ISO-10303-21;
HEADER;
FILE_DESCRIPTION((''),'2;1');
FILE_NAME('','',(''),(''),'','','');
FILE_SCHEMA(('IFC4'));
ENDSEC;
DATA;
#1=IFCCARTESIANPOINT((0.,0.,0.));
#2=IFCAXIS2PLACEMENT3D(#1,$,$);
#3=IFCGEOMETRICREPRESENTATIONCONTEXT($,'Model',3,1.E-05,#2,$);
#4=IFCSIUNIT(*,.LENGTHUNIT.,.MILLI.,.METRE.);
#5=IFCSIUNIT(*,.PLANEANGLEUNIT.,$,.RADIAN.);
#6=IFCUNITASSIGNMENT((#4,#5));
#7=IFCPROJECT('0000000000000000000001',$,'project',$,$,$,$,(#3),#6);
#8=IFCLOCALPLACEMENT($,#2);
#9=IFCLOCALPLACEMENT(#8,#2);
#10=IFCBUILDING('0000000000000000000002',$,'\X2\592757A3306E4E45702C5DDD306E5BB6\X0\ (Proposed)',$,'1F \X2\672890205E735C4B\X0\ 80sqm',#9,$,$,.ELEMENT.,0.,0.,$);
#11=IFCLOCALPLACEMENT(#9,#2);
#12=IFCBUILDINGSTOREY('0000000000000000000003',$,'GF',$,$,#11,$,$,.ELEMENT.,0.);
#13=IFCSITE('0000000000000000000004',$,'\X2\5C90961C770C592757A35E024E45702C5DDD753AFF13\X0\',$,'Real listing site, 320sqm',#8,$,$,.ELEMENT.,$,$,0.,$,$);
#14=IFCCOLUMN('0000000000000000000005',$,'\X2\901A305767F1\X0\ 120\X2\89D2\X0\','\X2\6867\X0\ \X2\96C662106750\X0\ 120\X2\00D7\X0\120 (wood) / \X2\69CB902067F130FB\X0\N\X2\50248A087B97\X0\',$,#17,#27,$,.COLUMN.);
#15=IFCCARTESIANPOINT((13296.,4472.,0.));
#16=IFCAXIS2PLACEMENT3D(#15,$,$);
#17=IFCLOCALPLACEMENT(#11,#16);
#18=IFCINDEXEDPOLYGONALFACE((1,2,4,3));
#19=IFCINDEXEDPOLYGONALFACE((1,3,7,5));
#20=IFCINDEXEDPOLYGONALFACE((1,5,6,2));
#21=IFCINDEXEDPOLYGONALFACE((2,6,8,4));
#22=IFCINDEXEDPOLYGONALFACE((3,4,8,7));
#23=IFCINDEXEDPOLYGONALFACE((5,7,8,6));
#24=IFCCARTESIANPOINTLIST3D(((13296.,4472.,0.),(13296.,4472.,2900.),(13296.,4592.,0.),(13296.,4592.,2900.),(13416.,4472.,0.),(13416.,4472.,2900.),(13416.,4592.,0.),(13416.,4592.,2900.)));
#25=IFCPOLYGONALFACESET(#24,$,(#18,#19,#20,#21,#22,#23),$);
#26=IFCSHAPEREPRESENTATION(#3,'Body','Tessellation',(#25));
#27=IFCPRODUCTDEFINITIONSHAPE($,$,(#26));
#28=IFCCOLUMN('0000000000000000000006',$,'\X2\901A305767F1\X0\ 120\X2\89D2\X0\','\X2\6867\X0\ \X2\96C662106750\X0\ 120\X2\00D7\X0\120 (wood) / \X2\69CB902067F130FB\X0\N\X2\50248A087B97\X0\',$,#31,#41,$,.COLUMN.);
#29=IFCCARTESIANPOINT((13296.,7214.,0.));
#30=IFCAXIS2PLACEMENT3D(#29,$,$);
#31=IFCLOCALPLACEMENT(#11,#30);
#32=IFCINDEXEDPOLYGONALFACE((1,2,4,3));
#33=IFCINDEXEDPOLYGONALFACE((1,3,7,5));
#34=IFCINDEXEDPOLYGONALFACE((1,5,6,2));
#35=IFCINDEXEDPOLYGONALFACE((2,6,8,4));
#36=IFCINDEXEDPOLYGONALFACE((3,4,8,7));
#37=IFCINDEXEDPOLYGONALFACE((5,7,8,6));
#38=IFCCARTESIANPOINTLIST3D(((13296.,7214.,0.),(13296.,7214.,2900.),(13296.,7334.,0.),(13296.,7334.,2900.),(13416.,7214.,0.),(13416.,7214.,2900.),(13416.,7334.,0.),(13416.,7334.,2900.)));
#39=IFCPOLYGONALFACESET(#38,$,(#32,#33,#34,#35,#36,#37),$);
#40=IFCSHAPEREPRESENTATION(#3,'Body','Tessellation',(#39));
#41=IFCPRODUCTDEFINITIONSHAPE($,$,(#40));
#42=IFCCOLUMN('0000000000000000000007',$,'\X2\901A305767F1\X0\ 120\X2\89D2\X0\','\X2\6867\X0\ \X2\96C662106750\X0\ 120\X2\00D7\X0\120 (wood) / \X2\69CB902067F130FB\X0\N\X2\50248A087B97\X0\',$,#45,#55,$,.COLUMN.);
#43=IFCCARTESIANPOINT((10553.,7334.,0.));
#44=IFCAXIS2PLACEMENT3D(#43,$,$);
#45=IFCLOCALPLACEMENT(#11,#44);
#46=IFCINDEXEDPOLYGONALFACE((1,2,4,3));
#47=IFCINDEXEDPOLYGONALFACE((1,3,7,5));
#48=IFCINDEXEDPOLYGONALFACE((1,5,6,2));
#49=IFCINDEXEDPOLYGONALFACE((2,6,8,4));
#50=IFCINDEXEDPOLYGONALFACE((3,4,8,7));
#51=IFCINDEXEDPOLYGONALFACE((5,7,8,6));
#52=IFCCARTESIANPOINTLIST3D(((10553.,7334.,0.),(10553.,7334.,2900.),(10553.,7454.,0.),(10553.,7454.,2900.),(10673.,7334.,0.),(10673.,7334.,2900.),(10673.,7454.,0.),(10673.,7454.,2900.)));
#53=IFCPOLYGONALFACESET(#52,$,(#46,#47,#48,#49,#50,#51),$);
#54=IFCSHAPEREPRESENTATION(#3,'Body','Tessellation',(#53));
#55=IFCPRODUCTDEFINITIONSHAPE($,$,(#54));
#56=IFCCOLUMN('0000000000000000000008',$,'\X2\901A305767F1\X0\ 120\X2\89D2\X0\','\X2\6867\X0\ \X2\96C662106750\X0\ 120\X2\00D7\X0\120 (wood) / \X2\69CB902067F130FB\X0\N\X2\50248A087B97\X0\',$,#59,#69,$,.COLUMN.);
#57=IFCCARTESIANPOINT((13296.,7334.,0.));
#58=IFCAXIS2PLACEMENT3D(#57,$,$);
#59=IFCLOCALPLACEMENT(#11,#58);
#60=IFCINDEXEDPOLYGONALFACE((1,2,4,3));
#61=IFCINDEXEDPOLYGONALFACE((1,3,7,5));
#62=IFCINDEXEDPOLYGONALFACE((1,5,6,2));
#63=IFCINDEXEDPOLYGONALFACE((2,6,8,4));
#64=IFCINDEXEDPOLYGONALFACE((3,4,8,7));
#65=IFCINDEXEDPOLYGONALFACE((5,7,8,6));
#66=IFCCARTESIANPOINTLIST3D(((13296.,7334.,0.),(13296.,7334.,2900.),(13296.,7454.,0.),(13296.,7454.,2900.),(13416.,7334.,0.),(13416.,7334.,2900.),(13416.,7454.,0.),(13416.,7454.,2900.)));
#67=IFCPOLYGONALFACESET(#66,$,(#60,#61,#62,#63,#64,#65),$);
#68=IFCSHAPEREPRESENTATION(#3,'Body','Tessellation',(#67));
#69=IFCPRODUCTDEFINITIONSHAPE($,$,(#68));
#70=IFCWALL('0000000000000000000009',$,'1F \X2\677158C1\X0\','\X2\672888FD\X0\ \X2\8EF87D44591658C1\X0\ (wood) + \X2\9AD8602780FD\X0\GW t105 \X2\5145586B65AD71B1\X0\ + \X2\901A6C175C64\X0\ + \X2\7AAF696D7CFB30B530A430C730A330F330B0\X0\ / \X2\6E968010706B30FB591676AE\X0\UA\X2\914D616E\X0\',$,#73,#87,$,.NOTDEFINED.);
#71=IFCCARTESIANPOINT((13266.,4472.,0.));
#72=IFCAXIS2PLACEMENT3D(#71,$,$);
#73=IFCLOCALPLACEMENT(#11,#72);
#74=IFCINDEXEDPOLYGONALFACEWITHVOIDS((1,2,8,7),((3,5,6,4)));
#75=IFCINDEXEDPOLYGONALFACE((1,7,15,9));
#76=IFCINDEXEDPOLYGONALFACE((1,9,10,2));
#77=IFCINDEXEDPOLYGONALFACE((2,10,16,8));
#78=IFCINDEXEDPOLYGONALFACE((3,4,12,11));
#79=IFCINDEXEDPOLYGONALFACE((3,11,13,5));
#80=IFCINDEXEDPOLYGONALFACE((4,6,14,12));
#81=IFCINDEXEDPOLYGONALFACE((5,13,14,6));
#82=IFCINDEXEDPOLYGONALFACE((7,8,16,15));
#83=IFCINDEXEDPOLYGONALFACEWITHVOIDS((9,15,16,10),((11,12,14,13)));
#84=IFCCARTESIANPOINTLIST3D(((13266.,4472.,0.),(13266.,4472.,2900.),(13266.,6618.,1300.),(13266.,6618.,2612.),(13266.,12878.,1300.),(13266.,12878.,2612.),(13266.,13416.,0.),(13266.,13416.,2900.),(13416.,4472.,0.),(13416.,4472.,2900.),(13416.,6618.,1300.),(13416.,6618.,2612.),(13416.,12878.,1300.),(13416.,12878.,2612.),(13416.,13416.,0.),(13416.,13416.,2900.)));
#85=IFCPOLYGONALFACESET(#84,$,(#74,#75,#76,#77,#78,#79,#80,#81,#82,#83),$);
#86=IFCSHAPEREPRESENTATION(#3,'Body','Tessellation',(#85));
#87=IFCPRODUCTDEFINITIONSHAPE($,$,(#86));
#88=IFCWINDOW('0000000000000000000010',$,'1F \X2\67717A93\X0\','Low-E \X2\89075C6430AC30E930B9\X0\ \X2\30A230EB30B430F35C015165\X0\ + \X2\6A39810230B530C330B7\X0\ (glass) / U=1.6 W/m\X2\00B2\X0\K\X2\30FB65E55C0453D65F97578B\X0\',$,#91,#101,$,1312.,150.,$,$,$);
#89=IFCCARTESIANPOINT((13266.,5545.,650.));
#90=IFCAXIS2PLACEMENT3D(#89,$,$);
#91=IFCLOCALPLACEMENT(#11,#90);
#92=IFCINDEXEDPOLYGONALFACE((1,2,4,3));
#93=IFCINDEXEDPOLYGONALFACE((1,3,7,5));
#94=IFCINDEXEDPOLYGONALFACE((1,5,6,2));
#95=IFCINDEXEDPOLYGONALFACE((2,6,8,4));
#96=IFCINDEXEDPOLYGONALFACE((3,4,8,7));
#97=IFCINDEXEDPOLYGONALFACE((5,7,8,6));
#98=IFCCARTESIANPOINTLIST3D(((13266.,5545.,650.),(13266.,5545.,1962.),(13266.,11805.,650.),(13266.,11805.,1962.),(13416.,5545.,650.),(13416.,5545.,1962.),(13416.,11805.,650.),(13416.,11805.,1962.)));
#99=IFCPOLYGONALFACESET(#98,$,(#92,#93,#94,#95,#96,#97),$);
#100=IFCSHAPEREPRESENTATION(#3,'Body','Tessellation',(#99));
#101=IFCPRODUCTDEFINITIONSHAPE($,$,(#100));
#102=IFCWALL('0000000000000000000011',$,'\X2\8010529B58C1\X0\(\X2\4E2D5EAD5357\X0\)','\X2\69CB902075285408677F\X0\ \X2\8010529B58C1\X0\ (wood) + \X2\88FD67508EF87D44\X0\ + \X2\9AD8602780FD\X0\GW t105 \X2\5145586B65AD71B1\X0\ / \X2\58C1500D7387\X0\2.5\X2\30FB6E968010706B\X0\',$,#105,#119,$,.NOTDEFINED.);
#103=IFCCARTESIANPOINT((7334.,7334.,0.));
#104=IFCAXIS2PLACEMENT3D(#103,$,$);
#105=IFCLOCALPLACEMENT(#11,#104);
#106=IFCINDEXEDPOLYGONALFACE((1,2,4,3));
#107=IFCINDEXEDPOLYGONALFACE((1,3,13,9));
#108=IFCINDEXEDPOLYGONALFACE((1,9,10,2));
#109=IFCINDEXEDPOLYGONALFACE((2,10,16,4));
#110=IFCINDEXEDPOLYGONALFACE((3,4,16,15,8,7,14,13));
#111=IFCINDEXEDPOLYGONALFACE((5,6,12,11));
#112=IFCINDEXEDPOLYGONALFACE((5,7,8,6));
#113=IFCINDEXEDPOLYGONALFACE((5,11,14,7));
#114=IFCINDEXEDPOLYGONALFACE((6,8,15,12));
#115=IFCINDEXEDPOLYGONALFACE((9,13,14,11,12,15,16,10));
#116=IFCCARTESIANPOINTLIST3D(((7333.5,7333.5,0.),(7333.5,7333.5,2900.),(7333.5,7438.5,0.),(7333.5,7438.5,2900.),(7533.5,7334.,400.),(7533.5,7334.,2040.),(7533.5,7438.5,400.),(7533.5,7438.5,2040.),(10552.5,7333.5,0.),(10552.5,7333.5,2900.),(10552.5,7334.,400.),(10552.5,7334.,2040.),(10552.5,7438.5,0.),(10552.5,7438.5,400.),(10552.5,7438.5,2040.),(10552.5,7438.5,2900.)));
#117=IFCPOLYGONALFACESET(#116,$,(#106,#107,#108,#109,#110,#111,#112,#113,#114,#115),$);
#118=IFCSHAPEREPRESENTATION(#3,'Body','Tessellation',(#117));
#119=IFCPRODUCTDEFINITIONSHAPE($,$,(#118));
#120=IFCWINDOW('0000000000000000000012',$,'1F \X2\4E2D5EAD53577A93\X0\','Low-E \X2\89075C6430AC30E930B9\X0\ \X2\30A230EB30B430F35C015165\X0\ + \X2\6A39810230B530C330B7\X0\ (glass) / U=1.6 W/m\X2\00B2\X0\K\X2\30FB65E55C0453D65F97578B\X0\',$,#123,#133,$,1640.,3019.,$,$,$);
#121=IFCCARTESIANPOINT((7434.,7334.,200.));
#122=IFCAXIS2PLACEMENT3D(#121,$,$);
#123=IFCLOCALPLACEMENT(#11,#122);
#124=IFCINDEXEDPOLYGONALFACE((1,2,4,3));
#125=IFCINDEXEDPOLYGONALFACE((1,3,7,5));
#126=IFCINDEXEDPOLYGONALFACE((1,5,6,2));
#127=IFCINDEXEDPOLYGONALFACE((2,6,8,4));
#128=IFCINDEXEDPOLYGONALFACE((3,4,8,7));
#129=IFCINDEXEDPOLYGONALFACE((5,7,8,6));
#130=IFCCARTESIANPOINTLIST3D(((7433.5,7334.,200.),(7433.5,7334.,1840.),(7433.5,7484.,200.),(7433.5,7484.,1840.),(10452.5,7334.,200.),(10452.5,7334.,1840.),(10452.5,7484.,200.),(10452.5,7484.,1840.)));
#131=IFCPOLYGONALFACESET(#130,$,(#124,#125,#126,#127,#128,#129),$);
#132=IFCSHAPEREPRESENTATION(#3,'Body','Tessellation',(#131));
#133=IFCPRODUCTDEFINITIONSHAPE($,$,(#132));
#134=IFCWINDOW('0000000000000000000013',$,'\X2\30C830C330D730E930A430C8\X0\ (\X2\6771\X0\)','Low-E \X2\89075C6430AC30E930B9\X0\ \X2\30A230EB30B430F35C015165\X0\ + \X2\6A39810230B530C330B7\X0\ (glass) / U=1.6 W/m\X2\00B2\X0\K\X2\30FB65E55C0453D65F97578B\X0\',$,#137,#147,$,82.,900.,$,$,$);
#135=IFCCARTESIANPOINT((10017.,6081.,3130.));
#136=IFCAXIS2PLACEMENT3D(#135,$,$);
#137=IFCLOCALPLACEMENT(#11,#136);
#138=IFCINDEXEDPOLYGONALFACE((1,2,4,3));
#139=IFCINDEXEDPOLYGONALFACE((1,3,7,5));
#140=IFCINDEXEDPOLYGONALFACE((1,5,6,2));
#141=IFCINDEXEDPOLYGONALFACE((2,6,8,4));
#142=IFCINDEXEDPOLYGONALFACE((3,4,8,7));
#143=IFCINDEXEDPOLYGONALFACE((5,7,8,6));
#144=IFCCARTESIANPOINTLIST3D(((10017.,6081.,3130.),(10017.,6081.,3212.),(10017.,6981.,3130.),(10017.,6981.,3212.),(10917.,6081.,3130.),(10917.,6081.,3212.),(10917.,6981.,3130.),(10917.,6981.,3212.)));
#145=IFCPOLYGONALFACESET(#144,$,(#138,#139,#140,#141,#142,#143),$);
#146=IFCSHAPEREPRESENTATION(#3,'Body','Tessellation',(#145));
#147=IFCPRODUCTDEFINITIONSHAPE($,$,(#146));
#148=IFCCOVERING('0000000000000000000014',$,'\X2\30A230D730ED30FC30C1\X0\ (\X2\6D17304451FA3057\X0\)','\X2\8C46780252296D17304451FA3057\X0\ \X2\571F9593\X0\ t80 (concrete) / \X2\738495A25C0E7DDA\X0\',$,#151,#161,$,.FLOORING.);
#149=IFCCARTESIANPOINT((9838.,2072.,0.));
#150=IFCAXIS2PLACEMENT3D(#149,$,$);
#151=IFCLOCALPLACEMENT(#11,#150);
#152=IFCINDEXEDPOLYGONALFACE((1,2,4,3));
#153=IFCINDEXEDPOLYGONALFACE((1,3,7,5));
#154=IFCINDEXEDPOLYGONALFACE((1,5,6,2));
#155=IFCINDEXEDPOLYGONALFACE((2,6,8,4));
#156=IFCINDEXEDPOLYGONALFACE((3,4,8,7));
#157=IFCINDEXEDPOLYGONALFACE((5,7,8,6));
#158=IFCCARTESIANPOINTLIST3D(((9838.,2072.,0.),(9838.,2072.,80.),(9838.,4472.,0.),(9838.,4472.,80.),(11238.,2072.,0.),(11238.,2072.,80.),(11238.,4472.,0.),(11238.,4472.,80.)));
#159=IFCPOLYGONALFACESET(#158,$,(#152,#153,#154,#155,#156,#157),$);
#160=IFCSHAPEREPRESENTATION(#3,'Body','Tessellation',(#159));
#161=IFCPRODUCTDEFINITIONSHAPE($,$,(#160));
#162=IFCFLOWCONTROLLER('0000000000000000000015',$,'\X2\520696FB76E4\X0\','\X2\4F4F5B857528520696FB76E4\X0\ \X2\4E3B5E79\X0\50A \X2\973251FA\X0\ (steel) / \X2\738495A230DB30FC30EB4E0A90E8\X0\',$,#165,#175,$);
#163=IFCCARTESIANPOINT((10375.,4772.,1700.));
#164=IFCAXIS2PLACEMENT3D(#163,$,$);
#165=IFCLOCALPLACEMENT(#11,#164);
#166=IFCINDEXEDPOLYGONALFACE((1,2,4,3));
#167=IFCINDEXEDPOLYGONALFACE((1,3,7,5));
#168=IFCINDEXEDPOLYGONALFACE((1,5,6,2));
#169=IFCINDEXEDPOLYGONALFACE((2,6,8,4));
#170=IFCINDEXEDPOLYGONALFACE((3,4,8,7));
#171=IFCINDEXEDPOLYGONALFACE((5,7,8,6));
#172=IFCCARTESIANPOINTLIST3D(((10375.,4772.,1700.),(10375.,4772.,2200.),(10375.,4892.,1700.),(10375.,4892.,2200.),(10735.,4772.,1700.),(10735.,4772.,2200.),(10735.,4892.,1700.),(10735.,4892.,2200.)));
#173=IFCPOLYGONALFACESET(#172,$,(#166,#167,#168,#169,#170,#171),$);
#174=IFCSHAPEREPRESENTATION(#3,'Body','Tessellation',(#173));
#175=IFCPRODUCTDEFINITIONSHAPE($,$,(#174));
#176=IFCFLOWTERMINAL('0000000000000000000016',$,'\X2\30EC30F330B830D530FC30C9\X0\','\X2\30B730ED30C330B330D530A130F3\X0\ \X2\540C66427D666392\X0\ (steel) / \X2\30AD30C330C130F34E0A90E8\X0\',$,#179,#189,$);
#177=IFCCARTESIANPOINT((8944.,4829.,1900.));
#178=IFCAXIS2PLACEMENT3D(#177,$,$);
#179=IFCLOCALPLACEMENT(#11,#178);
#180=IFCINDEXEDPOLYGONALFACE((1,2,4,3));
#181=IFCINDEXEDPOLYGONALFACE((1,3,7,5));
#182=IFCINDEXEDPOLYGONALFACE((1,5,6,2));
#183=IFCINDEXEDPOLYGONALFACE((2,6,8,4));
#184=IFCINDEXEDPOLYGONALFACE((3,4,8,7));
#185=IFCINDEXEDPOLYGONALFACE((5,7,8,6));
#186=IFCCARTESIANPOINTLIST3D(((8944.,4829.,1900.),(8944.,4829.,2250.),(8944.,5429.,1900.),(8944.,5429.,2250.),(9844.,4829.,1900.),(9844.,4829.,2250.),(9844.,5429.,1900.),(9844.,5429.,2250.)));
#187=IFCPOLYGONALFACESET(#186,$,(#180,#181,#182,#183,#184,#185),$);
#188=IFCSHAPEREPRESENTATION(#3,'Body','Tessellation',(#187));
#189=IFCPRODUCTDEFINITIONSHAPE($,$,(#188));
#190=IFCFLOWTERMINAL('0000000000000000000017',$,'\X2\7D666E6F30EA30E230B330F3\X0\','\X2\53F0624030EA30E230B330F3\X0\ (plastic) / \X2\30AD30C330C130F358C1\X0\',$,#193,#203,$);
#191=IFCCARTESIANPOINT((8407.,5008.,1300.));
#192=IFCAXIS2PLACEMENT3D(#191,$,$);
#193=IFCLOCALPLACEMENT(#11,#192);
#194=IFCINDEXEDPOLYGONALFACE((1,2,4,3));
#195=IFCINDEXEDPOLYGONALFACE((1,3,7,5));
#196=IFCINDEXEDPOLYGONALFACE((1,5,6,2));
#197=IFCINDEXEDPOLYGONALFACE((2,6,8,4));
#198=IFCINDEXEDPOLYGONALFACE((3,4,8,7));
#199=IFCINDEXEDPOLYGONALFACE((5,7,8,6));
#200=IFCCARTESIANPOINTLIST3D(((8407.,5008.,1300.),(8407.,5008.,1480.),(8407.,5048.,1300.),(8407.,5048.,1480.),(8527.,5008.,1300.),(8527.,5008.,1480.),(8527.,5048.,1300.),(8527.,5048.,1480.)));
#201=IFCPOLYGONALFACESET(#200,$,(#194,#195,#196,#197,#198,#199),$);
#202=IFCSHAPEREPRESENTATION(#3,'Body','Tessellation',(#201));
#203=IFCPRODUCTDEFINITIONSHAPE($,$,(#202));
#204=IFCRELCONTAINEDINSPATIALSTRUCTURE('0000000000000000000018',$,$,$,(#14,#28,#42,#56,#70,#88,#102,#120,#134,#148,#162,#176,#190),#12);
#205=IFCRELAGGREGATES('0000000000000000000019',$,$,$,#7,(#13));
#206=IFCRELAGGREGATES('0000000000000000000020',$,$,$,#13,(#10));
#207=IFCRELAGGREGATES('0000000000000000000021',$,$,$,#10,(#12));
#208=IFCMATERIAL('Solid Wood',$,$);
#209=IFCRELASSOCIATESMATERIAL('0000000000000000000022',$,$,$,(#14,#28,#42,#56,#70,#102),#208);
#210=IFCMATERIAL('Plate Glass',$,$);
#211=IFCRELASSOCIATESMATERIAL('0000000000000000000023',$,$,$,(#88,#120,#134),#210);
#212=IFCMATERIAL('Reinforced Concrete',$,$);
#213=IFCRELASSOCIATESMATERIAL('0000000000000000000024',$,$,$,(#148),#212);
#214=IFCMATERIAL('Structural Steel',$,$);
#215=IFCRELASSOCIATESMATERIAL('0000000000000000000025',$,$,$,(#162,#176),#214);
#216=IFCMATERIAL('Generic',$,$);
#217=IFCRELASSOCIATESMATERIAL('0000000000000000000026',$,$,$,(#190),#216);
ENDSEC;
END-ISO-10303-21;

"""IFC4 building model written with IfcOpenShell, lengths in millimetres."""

from ifc_helpers import new_model, si_unit, frame, frame_2d, origin, place, context, project, spatial, rectangle, extrude, material, element, fill, save


model = new_model("IFC4")

# Units and contexts
model_context = context("Model", 3, precision=1e-05, world=origin())
ifc_project = project(units=[si_unit("LENGTHUNIT", "METRE", prefix="MILLI"), si_unit("PLANEANGLEUNIT", "RADIAN")], contexts=[model_context])

# Site, building, storey
site_placement = place(None, origin())
site = spatial("IfcSite", under=ifc_project, at=site_placement, Name="岐阜県大垣市久瀬川町３", ObjectType="Real listing site, 320sqm", CompositionType="ELEMENT", RefElevation=0.0)
building_placement = place(site_placement, origin())
building = spatial("IfcBuilding", under=site, at=building_placement, Name="大垣の久瀬川の家 (Proposed)", ObjectType="1F 木造平屋 80sqm", CompositionType="ELEMENT", ElevationOfRefHeight=0.0, ElevationOfTerrain=0.0)
storey_placement = place(building_placement, origin())
storey = spatial("IfcBuildingStorey", under=building, at=storey_placement, Name="GF", CompositionType="ELEMENT", Elevation=0.0)

# Columns
ifc_material_1 = material(Name="Solid Wood")
column_1_placement = place(storey_placement, frame((13296.0, 4472.0, 0.0)))
element("IfcColumn", 1, at=column_1_placement, inside=storey, material=ifc_material_1, Name="通し柱 120角", Description="桧 集成材 120×120 (wood) / 構造柱・N値計算", PredefinedType="COLUMN", context=model_context, shape_type="SweptSolid", body=[
    extrude(rectangle(XDim=120.0, YDim=120.0, at=frame_2d((60.0, 60.0))), frame((13296.0, 4472.0, 0.0)), (0.0, 0.0, 1.0), 2900.0),
])
column_2_placement = place(storey_placement, frame((13296.0, 7214.0, 0.0)))
element("IfcColumn", 2, at=column_2_placement, inside=storey, material=ifc_material_1, Name="通し柱 120角", Description="桧 集成材 120×120 (wood) / 構造柱・N値計算", PredefinedType="COLUMN", context=model_context, shape_type="SweptSolid", body=[
    extrude(rectangle(XDim=120.0, YDim=120.0, at=frame_2d((60.0, 60.0))), frame((13296.0, 7214.0, 0.0)), (0.0, 0.0, 1.0), 2900.0),
])
column_3_placement = place(storey_placement, frame((10553.0, 7334.0, 0.0)))
element("IfcColumn", 3, at=column_3_placement, inside=storey, material=ifc_material_1, Name="通し柱 120角", Description="桧 集成材 120×120 (wood) / 構造柱・N値計算", PredefinedType="COLUMN", context=model_context, shape_type="SweptSolid", body=[
    extrude(rectangle(XDim=120.0, YDim=120.0, at=frame_2d((60.0, 60.0))), frame((10553.0, 7334.0, 0.0)), (0.0, 0.0, 1.0), 2900.0),
])
column_4_placement = place(storey_placement, frame((13296.0, 7334.0, 0.0)))
element("IfcColumn", 4, at=column_4_placement, inside=storey, material=ifc_material_1, Name="通し柱 120角", Description="桧 集成材 120×120 (wood) / 構造柱・N値計算", PredefinedType="COLUMN", context=model_context, shape_type="SweptSolid", body=[
    extrude(rectangle(XDim=120.0, YDim=120.0, at=frame_2d((60.0, 60.0))), frame((13296.0, 7334.0, 0.0)), (0.0, 0.0, 1.0), 2900.0),
])

# Walls, openings, windows
wall_1_placement = place(storey_placement, frame((13266.0, 4472.0, 0.0)))
wall_1 = element("IfcWall", 5, at=wall_1_placement, inside=storey, material=ifc_material_1, Name="1F 東壁", Description="木製 軸組外壁 (wood) + 高性能GW t105 充填断熱 + 通気層 + 窯業系サイディング / 準耐火・外皮UA配慮", PredefinedType="NOTDEFINED", context=model_context, shape_type="SweptSolid", body=[
    extrude(rectangle(XDim=150.0, YDim=8944.0, at=frame_2d((75.0, 4472.0))), frame((13266.0, 4472.0, 0.0)), (0.0, 0.0, 1.0), 2900.0),
])
opening_1_placement = place(storey_placement, frame((13266.0, 5545.0, 650.0)))
opening_1 = element("IfcOpeningElement", 6, at=opening_1_placement, cuts=wall_1, PredefinedType="NOTDEFINED", context=model_context, shape_type="SweptSolid", body=[
    extrude(rectangle(XDim=150.0, YDim=6260.0, at=frame_2d((75.0, 3130.0))), frame((13266.0, 5545.0, 650.0)), (0.0, 0.0, 1.0), 1312.0),
])
ifc_material_2 = material(Name="Plate Glass")
window_1_placement = place(storey_placement, frame((13266.0, 5545.0, 650.0)))
window_1 = element("IfcWindow", 7, at=window_1_placement, inside=storey, material=ifc_material_2, Name="1F 東窓", Description="Low-E 複層ガラス アルゴン封入 + 樹脂サッシ (glass) / U=1.6 W/m²K・日射取得型", OverallHeight=1312.0, OverallWidth=150.0, context=model_context, shape_type="SweptSolid", body=[
    extrude(rectangle(XDim=150.0, YDim=6260.0, at=frame_2d((75.0, 3130.0))), frame((13266.0, 5545.0, 650.0)), (0.0, 0.0, 1.0), 1312.0),
])
fill(opening_1, window_1)
wall_2_placement = place(storey_placement, frame((7334.0, 7334.0, 0.0)))
wall_2 = element("IfcWall", 8, at=wall_2_placement, inside=storey, material=ifc_material_1, Name="耐力壁(中庭南)", Description="構造用合板 耐力壁 (wood) + 製材軸組 + 高性能GW t105 充填断熱 / 壁倍率2.5・準耐火", PredefinedType="NOTDEFINED", context=model_context, shape_type="SweptSolid", body=[
    extrude(rectangle(XDim=3219.0, YDim=105.0, at=frame_2d((1609.0, 52.0))), frame((7334.0, 7334.0, 0.0)), (0.0, 0.0, 1.0), 2900.0),
])
opening_2_placement = place(storey_placement, frame((7434.0, 7334.0, 200.0)))
opening_2 = element("IfcOpeningElement", 9, at=opening_2_placement, cuts=wall_2, PredefinedType="NOTDEFINED", context=model_context, shape_type="SweptSolid", body=[
    extrude(rectangle(XDim=3019.0, YDim=150.0, at=frame_2d((1509.0, 75.0))), frame((7434.0, 7334.0, 200.0)), (0.0, 0.0, 1.0), 1640.0),
])
window_2_placement = place(storey_placement, frame((7434.0, 7334.0, 200.0)))
window_2 = element("IfcWindow", 10, at=window_2_placement, inside=storey, material=ifc_material_2, Name="1F 中庭南窓", Description="Low-E 複層ガラス アルゴン封入 + 樹脂サッシ (glass) / U=1.6 W/m²K・日射取得型", OverallHeight=1640.0, OverallWidth=3019.0, context=model_context, shape_type="SweptSolid", body=[
    extrude(rectangle(XDim=3019.0, YDim=150.0, at=frame_2d((1509.0, 75.0))), frame((7434.0, 7334.0, 200.0)), (0.0, 0.0, 1.0), 1640.0),
])
fill(opening_2, window_2)

# Window
window_3_placement = place(storey_placement, frame((10017.0, 6081.0, 3130.0)))
element("IfcWindow", 11, at=window_3_placement, inside=storey, material=ifc_material_2, Name="トップライト (東)", Description="Low-E 複層ガラス アルゴン封入 + 樹脂サッシ (glass) / U=1.6 W/m²K・日射取得型", OverallHeight=82.0, OverallWidth=900.0, context=model_context, shape_type="SweptSolid", body=[
    extrude(rectangle(XDim=900.0, YDim=900.0, at=frame_2d((450.0, 450.0))), frame((10017.0, 6081.0, 3130.0)), (0.0, 0.0, 1.0), 82.0),
])

# Shared definitions
ifc_material_3 = material(Name="Structural Steel")

# Covering
ifc_material_4 = material(Name="Reinforced Concrete")
covering_placement = place(storey_placement, frame((9838.0, 2072.0, 0.0)))
element("IfcCovering", 12, at=covering_placement, inside=storey, material=ifc_material_4, Name="アプローチ (洗い出し)", Description="豆砂利洗い出し 土間 t80 (concrete) / 玄関導線", PredefinedType="FLOORING", context=model_context, shape_type="SweptSolid", body=[
    extrude(rectangle(XDim=1400.0, YDim=2400.0, at=frame_2d((700.0, 1200.0))), frame((9838.0, 2072.0, 0.0)), (0.0, 0.0, 1.0), 80.0),
])

# Flow controller
flow_controller_placement = place(storey_placement, frame((10375.0, 4772.0, 1700.0)))
element("IfcFlowController", 13, at=flow_controller_placement, inside=storey, material=ifc_material_3, Name="分電盤", Description="住宅用分電盤 主幹50A 露出 (steel) / 玄関ホール上部", context=model_context, shape_type="SweptSolid", body=[
    extrude(rectangle(XDim=360.0, YDim=120.0, at=frame_2d((180.0, 60.0))), frame((10375.0, 4772.0, 1700.0)), (0.0, 0.0, 1.0), 500.0),
])

# Flow terminals
flow_terminal_1_placement = place(storey_placement, frame((8944.0, 4829.0, 1900.0)))
element("IfcFlowTerminal", 14, at=flow_terminal_1_placement, inside=storey, material=ifc_material_3, Name="レンジフード", Description="シロッコファン 同時給排 (steel) / キッチン上部", context=model_context, shape_type="SweptSolid", body=[
    extrude(rectangle(XDim=900.0, YDim=600.0, at=frame_2d((450.0, 300.0))), frame((8944.0, 4829.0, 1900.0)), (0.0, 0.0, 1.0), 350.0),
])
ifc_material_5 = material(Name="Generic")
flow_terminal_2_placement = place(storey_placement, frame((8407.0, 5008.0, 1300.0)))
element("IfcFlowTerminal", 15, at=flow_terminal_2_placement, inside=storey, material=ifc_material_5, Name="給湯リモコン", Description="台所リモコン (plastic) / キッチン壁", context=model_context, shape_type="SweptSolid", body=[
    extrude(rectangle(XDim=120.0, YDim=40.0, at=frame_2d((60.0, 20.0))), frame((8407.0, 5008.0, 1300.0)), (0.0, 0.0, 1.0), 180.0),
])

save(model, "model.ifc")
